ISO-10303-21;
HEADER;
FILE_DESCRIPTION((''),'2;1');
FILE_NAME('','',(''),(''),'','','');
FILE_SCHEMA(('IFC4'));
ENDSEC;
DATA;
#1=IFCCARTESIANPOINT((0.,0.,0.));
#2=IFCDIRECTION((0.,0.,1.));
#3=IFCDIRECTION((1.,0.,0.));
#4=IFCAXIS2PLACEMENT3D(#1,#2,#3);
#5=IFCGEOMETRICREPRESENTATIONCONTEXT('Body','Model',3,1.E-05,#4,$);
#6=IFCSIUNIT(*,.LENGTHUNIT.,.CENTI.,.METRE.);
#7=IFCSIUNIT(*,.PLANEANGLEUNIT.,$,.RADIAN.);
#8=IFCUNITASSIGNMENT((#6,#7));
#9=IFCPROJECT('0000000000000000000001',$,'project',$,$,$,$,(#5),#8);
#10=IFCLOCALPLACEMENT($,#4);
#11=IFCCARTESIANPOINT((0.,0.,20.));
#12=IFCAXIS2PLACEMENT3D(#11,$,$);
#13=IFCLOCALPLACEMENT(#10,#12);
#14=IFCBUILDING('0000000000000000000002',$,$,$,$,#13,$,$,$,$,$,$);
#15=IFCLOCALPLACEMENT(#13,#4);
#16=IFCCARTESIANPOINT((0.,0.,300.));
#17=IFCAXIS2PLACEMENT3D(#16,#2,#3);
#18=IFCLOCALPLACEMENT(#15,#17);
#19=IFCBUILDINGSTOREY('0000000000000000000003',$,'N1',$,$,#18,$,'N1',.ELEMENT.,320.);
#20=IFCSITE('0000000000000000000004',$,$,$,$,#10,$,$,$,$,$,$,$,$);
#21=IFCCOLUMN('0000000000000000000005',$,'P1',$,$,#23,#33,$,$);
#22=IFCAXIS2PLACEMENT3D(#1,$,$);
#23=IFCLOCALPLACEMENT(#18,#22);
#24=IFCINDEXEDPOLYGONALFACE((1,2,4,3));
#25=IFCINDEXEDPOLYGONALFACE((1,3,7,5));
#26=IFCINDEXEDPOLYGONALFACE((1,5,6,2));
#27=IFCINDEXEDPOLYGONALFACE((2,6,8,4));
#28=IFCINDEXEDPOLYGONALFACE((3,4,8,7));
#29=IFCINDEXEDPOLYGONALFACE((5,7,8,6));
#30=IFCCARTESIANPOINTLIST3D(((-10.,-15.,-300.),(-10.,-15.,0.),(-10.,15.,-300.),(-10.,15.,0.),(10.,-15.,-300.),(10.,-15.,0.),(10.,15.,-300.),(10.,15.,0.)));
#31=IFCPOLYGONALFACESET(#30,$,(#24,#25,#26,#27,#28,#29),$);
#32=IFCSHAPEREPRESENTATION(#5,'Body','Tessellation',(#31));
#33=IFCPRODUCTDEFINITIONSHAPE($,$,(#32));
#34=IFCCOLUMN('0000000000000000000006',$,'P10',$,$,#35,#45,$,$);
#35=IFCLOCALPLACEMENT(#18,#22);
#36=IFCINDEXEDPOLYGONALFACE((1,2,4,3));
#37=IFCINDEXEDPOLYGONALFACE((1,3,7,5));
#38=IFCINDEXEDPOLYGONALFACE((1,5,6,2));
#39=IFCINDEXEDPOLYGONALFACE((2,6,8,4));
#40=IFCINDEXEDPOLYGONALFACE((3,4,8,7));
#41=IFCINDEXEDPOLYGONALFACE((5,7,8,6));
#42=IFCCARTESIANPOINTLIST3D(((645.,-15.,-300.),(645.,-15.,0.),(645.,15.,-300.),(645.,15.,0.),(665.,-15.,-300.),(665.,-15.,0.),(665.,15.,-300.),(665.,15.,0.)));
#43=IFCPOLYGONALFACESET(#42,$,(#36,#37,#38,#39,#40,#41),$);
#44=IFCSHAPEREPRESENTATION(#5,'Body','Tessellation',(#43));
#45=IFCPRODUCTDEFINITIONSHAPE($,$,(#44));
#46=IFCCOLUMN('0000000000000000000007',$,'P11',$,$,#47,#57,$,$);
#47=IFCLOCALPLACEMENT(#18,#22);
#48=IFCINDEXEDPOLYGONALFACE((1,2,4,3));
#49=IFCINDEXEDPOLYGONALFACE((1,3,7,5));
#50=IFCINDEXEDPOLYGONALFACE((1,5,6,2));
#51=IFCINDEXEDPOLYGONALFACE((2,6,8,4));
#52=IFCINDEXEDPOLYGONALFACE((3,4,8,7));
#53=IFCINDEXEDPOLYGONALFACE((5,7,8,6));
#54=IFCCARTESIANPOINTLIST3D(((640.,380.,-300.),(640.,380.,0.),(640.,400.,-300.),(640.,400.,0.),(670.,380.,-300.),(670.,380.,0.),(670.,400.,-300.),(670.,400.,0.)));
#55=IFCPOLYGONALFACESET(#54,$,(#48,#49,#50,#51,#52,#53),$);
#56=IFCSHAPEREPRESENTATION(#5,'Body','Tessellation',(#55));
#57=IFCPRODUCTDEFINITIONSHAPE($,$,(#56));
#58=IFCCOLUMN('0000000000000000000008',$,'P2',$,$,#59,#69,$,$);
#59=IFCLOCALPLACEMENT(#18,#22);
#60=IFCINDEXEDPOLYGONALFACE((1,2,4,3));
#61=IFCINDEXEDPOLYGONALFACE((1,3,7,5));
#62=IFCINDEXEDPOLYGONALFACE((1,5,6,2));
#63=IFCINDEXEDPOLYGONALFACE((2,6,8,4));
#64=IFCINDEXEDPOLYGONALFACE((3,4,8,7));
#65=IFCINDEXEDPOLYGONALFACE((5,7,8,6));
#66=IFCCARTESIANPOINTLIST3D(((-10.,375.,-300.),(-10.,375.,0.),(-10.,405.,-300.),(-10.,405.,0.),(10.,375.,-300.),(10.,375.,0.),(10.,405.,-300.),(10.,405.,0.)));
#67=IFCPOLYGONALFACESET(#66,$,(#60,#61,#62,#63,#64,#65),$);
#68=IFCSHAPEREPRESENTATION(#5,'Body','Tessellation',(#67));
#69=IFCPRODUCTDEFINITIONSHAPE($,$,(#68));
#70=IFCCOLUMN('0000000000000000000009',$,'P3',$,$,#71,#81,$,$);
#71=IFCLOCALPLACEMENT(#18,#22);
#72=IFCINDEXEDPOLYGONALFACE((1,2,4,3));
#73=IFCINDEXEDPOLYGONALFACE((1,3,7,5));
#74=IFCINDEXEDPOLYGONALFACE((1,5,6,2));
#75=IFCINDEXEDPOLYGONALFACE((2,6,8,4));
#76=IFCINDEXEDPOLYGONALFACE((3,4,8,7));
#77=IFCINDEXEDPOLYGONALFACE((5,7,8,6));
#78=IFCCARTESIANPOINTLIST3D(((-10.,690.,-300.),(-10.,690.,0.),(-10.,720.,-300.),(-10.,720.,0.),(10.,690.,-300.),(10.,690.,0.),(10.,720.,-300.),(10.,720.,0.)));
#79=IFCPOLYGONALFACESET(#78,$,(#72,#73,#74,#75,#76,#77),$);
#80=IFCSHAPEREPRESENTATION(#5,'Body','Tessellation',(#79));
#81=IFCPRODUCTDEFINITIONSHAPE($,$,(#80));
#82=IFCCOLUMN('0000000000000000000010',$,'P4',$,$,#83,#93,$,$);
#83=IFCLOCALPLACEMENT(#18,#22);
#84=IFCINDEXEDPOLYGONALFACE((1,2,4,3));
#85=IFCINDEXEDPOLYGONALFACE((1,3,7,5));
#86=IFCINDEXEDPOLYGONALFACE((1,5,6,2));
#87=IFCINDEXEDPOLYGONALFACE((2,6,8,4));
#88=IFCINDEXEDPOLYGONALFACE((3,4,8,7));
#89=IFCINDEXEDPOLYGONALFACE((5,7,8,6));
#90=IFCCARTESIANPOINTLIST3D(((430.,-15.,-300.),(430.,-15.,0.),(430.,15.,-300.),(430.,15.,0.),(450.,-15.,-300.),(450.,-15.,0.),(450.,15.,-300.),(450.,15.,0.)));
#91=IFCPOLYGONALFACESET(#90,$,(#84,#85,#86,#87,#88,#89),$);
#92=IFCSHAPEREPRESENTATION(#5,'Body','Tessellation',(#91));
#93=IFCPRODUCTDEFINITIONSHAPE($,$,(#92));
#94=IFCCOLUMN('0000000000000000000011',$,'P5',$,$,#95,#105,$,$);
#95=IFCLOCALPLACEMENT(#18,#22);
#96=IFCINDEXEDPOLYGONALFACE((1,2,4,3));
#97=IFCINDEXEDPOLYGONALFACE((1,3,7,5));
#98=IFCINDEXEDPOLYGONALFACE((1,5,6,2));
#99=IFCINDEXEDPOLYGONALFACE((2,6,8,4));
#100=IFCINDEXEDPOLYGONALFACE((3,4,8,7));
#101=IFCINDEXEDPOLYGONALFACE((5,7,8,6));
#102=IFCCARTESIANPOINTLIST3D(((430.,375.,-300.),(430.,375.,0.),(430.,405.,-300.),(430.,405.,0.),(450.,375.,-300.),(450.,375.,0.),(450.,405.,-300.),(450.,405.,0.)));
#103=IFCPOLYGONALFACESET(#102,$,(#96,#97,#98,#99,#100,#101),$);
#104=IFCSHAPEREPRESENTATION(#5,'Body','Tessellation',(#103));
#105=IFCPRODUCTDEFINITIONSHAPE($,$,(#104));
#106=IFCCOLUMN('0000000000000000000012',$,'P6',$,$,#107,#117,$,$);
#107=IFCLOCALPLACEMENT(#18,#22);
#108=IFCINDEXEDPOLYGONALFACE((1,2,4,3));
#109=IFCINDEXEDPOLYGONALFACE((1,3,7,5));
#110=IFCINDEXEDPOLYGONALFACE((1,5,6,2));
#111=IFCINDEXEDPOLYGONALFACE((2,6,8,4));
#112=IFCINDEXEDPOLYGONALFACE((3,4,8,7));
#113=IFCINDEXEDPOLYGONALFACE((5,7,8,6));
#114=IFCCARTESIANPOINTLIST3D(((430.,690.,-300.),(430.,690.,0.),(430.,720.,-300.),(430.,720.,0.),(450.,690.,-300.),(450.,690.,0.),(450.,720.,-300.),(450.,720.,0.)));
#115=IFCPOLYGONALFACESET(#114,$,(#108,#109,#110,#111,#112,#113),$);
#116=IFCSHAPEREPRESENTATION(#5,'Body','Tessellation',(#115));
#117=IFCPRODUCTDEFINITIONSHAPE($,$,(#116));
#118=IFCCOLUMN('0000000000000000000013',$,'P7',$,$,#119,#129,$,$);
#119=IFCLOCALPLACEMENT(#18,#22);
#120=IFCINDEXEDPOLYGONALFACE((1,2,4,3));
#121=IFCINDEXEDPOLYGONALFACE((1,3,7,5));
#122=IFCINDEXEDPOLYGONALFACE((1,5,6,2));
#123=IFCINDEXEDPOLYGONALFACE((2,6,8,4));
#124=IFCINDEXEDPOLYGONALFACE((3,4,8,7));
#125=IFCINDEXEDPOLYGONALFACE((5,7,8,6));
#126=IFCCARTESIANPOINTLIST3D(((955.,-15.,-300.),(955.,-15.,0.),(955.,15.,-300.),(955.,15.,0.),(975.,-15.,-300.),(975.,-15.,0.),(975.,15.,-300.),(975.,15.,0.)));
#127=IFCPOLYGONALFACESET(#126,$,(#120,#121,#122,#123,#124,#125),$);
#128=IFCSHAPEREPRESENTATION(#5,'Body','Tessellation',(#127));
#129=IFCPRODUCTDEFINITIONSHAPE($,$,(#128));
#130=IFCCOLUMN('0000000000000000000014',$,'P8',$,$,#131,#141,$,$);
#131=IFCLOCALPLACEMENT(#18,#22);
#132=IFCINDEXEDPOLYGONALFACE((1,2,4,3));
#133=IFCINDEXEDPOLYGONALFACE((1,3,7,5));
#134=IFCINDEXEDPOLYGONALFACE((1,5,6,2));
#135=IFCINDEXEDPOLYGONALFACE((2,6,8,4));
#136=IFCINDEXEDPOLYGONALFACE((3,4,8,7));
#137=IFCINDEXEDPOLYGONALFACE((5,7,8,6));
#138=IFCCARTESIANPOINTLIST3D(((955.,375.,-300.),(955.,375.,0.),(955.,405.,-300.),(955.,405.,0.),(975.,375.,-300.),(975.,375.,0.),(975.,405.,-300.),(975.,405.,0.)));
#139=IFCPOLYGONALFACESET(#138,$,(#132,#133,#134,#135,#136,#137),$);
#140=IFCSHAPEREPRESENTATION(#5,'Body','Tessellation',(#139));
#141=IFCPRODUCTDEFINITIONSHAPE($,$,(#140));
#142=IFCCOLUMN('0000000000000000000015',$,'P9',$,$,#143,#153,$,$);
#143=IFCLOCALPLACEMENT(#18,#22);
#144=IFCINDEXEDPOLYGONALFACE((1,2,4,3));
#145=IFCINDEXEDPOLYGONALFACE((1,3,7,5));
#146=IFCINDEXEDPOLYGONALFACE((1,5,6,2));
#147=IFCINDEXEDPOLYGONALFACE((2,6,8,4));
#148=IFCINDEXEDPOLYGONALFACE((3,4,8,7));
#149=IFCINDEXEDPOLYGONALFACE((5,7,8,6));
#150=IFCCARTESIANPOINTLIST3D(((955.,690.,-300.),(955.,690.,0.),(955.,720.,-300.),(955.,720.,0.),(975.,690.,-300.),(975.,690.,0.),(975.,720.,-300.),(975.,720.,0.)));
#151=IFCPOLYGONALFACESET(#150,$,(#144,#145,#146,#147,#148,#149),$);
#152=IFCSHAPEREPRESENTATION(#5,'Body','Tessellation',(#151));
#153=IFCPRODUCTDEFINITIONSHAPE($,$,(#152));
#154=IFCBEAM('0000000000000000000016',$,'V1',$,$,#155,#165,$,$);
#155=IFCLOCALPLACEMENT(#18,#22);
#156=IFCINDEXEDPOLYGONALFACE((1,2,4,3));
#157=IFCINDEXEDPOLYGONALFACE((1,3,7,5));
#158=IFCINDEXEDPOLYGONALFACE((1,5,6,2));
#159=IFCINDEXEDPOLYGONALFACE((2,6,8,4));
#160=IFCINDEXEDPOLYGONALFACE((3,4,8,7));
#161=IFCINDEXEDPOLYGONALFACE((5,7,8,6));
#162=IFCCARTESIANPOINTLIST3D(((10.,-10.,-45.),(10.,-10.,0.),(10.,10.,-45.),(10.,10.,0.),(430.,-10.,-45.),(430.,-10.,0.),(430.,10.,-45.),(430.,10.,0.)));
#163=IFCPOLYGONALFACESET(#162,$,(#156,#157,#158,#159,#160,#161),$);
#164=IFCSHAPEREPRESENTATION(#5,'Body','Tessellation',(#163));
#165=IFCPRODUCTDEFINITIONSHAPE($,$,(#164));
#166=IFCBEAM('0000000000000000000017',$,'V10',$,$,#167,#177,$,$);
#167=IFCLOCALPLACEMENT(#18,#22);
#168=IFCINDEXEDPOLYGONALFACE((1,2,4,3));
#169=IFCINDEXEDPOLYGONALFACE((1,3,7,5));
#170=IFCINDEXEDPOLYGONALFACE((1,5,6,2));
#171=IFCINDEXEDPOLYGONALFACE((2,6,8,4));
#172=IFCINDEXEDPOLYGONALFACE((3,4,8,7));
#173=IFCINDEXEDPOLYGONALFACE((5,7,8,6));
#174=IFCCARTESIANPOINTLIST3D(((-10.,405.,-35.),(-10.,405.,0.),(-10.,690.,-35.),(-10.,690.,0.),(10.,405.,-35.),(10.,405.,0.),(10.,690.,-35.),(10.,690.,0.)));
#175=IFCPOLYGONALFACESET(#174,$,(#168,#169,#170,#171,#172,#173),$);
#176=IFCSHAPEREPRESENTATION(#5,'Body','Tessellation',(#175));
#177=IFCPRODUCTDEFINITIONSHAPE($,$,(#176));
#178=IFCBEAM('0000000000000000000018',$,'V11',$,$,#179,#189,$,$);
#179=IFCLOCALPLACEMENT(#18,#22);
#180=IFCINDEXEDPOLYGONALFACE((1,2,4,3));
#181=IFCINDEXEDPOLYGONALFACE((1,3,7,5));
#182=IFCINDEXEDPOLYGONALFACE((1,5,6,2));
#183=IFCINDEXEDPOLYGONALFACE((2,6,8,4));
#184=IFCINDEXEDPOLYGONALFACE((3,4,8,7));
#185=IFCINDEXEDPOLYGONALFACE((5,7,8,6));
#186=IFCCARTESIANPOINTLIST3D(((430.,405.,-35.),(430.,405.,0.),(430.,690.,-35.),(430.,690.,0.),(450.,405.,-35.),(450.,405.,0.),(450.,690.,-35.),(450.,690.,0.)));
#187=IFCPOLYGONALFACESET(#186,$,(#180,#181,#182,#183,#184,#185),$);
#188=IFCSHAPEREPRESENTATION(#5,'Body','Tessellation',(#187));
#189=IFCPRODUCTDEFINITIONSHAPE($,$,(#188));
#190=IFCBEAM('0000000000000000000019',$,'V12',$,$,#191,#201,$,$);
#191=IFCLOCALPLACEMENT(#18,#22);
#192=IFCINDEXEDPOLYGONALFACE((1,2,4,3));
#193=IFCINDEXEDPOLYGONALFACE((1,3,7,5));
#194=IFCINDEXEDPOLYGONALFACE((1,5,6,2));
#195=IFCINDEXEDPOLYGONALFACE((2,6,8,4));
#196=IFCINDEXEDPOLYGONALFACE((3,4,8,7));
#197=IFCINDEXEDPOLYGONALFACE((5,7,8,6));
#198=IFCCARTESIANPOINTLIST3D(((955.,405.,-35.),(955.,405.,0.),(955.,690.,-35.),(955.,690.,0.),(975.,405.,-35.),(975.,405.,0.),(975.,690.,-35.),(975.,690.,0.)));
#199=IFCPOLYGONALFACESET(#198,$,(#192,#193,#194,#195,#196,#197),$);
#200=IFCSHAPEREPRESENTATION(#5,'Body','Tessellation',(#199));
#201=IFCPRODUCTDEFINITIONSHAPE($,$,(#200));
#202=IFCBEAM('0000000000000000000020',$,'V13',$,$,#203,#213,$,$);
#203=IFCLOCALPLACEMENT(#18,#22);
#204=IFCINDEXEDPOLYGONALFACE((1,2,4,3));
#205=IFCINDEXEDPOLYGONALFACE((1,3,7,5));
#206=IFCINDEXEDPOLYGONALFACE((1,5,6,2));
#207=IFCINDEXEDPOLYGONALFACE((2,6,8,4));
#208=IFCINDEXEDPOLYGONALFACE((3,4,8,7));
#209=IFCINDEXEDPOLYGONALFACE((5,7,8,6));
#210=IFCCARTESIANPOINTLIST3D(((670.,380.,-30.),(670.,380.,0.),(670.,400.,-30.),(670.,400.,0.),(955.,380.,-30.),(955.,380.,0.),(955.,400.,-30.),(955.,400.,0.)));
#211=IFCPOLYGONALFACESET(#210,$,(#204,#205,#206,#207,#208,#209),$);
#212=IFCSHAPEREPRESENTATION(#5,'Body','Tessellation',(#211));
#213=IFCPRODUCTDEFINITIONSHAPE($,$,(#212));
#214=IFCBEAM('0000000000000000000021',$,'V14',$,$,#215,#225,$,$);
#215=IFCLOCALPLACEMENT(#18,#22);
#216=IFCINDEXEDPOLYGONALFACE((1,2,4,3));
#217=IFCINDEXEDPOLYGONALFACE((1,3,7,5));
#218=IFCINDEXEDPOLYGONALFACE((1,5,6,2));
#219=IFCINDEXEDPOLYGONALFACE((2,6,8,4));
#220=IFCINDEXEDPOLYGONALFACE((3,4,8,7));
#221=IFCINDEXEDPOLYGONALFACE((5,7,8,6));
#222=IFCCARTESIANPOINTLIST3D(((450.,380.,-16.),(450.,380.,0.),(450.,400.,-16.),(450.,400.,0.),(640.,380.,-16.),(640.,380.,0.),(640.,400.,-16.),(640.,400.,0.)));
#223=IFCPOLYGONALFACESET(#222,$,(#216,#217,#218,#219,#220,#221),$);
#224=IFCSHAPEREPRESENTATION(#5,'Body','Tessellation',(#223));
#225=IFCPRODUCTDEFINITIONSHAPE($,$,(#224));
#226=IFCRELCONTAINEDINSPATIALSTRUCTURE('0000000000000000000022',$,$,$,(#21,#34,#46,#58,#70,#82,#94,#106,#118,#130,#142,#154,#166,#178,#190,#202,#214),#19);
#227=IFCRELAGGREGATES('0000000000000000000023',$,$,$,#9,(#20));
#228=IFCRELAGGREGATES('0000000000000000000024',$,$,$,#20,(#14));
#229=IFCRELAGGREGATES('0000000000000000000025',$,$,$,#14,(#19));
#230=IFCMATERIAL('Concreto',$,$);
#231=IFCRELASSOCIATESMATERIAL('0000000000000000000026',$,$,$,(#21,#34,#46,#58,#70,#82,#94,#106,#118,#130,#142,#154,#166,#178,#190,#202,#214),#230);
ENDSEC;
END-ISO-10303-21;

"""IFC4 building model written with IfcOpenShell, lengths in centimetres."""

from ifc_helpers import new_model, si_unit, frame, origin_with_axes, origin_2d_with_axis, place, context, project, spatial, rectangle, extrude, material, element, save


model = new_model("IFC4")

# Units and contexts
model_context = context("Model", 3, precision=1e-05, world=origin_with_axes(), identifier="Body")
ifc_project = project(units=[si_unit("LENGTHUNIT", "METRE", prefix="CENTI"), si_unit("PLANEANGLEUNIT", "RADIAN")], contexts=[model_context])

# Site, building, storey
site_placement = place(None, origin_with_axes())
site = spatial("IfcSite", under=ifc_project, at=site_placement)
building_placement = place(site_placement, frame((0.0, 0.0, 20.0)))
building = spatial("IfcBuilding", under=site, at=building_placement)
placement = place(building_placement, origin_with_axes())
storey_placement = place(placement, frame((0.0, 0.0, 300.0), z_axis=(0.0, 0.0, 1.0), x_axis=(1.0, 0.0, 0.0)))
storey = spatial("IfcBuildingStorey", under=building, at=storey_placement, Name="N1", LongName="N1", CompositionType="ELEMENT", Elevation=320.0)

# Columns
ifc_material = material(Name="Concreto")
for number, where, z_axis, x_axis, name in (
    (1, (0.0, 0.0, 0.0), (0.0, 0.0, 1.0), (1.0, 0.0, 0.0), "P1"),
    (2, (655.0, 0.0, 0.0), (0.0, 0.0, 1.0), (1.0, 0.0, 0.0), "P10"),
):
    element("IfcColumn", number, at=place(storey_placement, frame(where, z_axis=z_axis, x_axis=x_axis)), inside=storey, material=ifc_material, Name=name, context=model_context, shape_type="SolidModel", body=[
        extrude(rectangle(XDim=20.0, YDim=30.0, at=origin_2d_with_axis()), origin_with_axes(), (0.0, 0.0, -1.0), 300.0),
    ])
column_placement = place(storey_placement, frame((655.0, 390.0, 0.0), z_axis=(0.0, 0.0, 1.0), x_axis=(1.0, 0.0, 0.0)))
element("IfcColumn", 3, at=column_placement, inside=storey, material=ifc_material, Name="P11", context=model_context, shape_type="SolidModel", body=[
    extrude(rectangle(XDim=20.0, YDim=30.0, at=origin_2d_with_axis()), frame((0.0, 0.0, 0.0), z_axis=(0.0, 0.0, 1.0), x_axis=(0.0, 1.0, 0.0)), (0.0, 0.0, -1.0), 300.0),
])
for number, where, z_axis, x_axis, name in (
    (4, (0.0, 390.0, 0.0), (0.0, 0.0, 1.0), (1.0, 0.0, 0.0), "P2"),
    (5, (0.0, 705.0, 0.0), (0.0, 0.0, 1.0), (1.0, 0.0, 0.0), "P3"),
    (6, (440.0, 0.0, 0.0), (0.0, 0.0, 1.0), (1.0, 0.0, 0.0), "P4"),
    (7, (440.0, 390.0, 0.0), (0.0, 0.0, 1.0), (1.0, 0.0, 0.0), "P5"),
    (8, (440.0, 705.0, 0.0), (0.0, 0.0, 1.0), (1.0, 0.0, 0.0), "P6"),
    (9, (965.0, 0.0, 0.0), (0.0, 0.0, 1.0), (1.0, 0.0, 0.0), "P7"),
    (10, (965.0, 390.0, 0.0), (0.0, 0.0, 1.0), (1.0, 0.0, 0.0), "P8"),
    (11, (965.0, 705.0, 0.0), (0.0, 0.0, 1.0), (1.0, 0.0, 0.0), "P9"),
):
    element("IfcColumn", number, at=place(storey_placement, frame(where, z_axis=z_axis, x_axis=x_axis)), inside=storey, material=ifc_material, Name=name, context=model_context, shape_type="SolidModel", body=[
        extrude(rectangle(XDim=20.0, YDim=30.0, at=origin_2d_with_axis()), origin_with_axes(), (0.0, 0.0, -1.0), 300.0),
    ])

# Beams
beam_1_placement = place(storey_placement, frame((220.0, 0.0, 0.0), z_axis=(0.0, 0.0, 1.0), x_axis=(1.0, 0.0, 0.0)))
element("IfcBeam", 12, at=beam_1_placement, inside=storey, material=ifc_material, Name="V1", context=model_context, shape_type="SolidModel", body=[
    extrude(rectangle(XDim=20.0, YDim=45.0, at=origin_2d_with_axis()), frame((-210.0, 0.0, -22.5), z_axis=(1.0, 0.0, 0.0), x_axis=(0.0, 1.0, 0.0)), (0.0, 0.0, 1.0), 420.0),
])
beam_2_placement = place(storey_placement, frame((0.0, 547.5, 0.0), z_axis=(0.0, 0.0, 1.0), x_axis=(1.0, 0.0, 0.0)))
element("IfcBeam", 13, at=beam_2_placement, inside=storey, material=ifc_material, Name="V10", context=model_context, shape_type="SolidModel", body=[
    extrude(rectangle(XDim=20.0, YDim=35.0, at=origin_2d_with_axis()), frame((0.0, -142.5, -17.5), z_axis=(0.0, 1.0, 0.0), x_axis=(-1.0, 0.0, 0.0)), (0.0, 0.0, 1.0), 285.0),
])
for number, where, z_axis, x_axis, name in (
    (14, (440.0, 547.5, 0.0), (0.0, 0.0, 1.0), (1.0, 0.0, 0.0), "V11"),
    (15, (965.0, 547.5, 0.0), (0.0, 0.0, 1.0), (1.0, 0.0, 0.0), "V12"),
):
    element("IfcBeam", number, at=place(storey_placement, frame(where, z_axis=z_axis, x_axis=x_axis)), inside=storey, material=ifc_material, Name=name, context=model_context, shape_type="SolidModel", body=[
        extrude(rectangle(XDim=20.0, YDim=35.0, at=origin_2d_with_axis()), frame((0.0, -142.5, -17.5), z_axis=(0.0, 1.0, 0.0), x_axis=(1.0, 0.0, 0.0)), (0.0, 0.0, 1.0), 285.0),
    ])
beam_3_placement = place(storey_placement, frame((812.5, 390.0, 0.0), z_axis=(0.0, 0.0, 1.0), x_axis=(1.0, 0.0, 0.0)))
element("IfcBeam", 16, at=beam_3_placement, inside=storey, material=ifc_material, Name="V13", context=model_context, shape_type="SolidModel", body=[
    extrude(rectangle(XDim=20.0, YDim=30.0, at=origin_2d_with_axis()), frame((-142.5, 0.0, -15.0), z_axis=(1.0, 0.0, 0.0), x_axis=(0.0, 1.0, 0.0)), (0.0, 0.0, 1.0), 285.0),
])
beam_4_placement = place(storey_placement, frame((545.0, 390.0, 0.0), z_axis=(0.0, 0.0, 1.0), x_axis=(1.0, 0.0, 0.0)))
element("IfcBeam", 17, at=beam_4_placement, inside=storey, material=ifc_material, Name="V14", context=model_context, shape_type="SolidModel", body=[
    extrude(rectangle(XDim=20.0, YDim=16.0, at=origin_2d_with_axis()), frame((-95.0, 0.0, -8.0), z_axis=(1.0, 0.0, 0.0), x_axis=(0.0, 1.0, 0.0)), (0.0, 0.0, 1.0), 190.0),
])

save(model, "model.ifc")
